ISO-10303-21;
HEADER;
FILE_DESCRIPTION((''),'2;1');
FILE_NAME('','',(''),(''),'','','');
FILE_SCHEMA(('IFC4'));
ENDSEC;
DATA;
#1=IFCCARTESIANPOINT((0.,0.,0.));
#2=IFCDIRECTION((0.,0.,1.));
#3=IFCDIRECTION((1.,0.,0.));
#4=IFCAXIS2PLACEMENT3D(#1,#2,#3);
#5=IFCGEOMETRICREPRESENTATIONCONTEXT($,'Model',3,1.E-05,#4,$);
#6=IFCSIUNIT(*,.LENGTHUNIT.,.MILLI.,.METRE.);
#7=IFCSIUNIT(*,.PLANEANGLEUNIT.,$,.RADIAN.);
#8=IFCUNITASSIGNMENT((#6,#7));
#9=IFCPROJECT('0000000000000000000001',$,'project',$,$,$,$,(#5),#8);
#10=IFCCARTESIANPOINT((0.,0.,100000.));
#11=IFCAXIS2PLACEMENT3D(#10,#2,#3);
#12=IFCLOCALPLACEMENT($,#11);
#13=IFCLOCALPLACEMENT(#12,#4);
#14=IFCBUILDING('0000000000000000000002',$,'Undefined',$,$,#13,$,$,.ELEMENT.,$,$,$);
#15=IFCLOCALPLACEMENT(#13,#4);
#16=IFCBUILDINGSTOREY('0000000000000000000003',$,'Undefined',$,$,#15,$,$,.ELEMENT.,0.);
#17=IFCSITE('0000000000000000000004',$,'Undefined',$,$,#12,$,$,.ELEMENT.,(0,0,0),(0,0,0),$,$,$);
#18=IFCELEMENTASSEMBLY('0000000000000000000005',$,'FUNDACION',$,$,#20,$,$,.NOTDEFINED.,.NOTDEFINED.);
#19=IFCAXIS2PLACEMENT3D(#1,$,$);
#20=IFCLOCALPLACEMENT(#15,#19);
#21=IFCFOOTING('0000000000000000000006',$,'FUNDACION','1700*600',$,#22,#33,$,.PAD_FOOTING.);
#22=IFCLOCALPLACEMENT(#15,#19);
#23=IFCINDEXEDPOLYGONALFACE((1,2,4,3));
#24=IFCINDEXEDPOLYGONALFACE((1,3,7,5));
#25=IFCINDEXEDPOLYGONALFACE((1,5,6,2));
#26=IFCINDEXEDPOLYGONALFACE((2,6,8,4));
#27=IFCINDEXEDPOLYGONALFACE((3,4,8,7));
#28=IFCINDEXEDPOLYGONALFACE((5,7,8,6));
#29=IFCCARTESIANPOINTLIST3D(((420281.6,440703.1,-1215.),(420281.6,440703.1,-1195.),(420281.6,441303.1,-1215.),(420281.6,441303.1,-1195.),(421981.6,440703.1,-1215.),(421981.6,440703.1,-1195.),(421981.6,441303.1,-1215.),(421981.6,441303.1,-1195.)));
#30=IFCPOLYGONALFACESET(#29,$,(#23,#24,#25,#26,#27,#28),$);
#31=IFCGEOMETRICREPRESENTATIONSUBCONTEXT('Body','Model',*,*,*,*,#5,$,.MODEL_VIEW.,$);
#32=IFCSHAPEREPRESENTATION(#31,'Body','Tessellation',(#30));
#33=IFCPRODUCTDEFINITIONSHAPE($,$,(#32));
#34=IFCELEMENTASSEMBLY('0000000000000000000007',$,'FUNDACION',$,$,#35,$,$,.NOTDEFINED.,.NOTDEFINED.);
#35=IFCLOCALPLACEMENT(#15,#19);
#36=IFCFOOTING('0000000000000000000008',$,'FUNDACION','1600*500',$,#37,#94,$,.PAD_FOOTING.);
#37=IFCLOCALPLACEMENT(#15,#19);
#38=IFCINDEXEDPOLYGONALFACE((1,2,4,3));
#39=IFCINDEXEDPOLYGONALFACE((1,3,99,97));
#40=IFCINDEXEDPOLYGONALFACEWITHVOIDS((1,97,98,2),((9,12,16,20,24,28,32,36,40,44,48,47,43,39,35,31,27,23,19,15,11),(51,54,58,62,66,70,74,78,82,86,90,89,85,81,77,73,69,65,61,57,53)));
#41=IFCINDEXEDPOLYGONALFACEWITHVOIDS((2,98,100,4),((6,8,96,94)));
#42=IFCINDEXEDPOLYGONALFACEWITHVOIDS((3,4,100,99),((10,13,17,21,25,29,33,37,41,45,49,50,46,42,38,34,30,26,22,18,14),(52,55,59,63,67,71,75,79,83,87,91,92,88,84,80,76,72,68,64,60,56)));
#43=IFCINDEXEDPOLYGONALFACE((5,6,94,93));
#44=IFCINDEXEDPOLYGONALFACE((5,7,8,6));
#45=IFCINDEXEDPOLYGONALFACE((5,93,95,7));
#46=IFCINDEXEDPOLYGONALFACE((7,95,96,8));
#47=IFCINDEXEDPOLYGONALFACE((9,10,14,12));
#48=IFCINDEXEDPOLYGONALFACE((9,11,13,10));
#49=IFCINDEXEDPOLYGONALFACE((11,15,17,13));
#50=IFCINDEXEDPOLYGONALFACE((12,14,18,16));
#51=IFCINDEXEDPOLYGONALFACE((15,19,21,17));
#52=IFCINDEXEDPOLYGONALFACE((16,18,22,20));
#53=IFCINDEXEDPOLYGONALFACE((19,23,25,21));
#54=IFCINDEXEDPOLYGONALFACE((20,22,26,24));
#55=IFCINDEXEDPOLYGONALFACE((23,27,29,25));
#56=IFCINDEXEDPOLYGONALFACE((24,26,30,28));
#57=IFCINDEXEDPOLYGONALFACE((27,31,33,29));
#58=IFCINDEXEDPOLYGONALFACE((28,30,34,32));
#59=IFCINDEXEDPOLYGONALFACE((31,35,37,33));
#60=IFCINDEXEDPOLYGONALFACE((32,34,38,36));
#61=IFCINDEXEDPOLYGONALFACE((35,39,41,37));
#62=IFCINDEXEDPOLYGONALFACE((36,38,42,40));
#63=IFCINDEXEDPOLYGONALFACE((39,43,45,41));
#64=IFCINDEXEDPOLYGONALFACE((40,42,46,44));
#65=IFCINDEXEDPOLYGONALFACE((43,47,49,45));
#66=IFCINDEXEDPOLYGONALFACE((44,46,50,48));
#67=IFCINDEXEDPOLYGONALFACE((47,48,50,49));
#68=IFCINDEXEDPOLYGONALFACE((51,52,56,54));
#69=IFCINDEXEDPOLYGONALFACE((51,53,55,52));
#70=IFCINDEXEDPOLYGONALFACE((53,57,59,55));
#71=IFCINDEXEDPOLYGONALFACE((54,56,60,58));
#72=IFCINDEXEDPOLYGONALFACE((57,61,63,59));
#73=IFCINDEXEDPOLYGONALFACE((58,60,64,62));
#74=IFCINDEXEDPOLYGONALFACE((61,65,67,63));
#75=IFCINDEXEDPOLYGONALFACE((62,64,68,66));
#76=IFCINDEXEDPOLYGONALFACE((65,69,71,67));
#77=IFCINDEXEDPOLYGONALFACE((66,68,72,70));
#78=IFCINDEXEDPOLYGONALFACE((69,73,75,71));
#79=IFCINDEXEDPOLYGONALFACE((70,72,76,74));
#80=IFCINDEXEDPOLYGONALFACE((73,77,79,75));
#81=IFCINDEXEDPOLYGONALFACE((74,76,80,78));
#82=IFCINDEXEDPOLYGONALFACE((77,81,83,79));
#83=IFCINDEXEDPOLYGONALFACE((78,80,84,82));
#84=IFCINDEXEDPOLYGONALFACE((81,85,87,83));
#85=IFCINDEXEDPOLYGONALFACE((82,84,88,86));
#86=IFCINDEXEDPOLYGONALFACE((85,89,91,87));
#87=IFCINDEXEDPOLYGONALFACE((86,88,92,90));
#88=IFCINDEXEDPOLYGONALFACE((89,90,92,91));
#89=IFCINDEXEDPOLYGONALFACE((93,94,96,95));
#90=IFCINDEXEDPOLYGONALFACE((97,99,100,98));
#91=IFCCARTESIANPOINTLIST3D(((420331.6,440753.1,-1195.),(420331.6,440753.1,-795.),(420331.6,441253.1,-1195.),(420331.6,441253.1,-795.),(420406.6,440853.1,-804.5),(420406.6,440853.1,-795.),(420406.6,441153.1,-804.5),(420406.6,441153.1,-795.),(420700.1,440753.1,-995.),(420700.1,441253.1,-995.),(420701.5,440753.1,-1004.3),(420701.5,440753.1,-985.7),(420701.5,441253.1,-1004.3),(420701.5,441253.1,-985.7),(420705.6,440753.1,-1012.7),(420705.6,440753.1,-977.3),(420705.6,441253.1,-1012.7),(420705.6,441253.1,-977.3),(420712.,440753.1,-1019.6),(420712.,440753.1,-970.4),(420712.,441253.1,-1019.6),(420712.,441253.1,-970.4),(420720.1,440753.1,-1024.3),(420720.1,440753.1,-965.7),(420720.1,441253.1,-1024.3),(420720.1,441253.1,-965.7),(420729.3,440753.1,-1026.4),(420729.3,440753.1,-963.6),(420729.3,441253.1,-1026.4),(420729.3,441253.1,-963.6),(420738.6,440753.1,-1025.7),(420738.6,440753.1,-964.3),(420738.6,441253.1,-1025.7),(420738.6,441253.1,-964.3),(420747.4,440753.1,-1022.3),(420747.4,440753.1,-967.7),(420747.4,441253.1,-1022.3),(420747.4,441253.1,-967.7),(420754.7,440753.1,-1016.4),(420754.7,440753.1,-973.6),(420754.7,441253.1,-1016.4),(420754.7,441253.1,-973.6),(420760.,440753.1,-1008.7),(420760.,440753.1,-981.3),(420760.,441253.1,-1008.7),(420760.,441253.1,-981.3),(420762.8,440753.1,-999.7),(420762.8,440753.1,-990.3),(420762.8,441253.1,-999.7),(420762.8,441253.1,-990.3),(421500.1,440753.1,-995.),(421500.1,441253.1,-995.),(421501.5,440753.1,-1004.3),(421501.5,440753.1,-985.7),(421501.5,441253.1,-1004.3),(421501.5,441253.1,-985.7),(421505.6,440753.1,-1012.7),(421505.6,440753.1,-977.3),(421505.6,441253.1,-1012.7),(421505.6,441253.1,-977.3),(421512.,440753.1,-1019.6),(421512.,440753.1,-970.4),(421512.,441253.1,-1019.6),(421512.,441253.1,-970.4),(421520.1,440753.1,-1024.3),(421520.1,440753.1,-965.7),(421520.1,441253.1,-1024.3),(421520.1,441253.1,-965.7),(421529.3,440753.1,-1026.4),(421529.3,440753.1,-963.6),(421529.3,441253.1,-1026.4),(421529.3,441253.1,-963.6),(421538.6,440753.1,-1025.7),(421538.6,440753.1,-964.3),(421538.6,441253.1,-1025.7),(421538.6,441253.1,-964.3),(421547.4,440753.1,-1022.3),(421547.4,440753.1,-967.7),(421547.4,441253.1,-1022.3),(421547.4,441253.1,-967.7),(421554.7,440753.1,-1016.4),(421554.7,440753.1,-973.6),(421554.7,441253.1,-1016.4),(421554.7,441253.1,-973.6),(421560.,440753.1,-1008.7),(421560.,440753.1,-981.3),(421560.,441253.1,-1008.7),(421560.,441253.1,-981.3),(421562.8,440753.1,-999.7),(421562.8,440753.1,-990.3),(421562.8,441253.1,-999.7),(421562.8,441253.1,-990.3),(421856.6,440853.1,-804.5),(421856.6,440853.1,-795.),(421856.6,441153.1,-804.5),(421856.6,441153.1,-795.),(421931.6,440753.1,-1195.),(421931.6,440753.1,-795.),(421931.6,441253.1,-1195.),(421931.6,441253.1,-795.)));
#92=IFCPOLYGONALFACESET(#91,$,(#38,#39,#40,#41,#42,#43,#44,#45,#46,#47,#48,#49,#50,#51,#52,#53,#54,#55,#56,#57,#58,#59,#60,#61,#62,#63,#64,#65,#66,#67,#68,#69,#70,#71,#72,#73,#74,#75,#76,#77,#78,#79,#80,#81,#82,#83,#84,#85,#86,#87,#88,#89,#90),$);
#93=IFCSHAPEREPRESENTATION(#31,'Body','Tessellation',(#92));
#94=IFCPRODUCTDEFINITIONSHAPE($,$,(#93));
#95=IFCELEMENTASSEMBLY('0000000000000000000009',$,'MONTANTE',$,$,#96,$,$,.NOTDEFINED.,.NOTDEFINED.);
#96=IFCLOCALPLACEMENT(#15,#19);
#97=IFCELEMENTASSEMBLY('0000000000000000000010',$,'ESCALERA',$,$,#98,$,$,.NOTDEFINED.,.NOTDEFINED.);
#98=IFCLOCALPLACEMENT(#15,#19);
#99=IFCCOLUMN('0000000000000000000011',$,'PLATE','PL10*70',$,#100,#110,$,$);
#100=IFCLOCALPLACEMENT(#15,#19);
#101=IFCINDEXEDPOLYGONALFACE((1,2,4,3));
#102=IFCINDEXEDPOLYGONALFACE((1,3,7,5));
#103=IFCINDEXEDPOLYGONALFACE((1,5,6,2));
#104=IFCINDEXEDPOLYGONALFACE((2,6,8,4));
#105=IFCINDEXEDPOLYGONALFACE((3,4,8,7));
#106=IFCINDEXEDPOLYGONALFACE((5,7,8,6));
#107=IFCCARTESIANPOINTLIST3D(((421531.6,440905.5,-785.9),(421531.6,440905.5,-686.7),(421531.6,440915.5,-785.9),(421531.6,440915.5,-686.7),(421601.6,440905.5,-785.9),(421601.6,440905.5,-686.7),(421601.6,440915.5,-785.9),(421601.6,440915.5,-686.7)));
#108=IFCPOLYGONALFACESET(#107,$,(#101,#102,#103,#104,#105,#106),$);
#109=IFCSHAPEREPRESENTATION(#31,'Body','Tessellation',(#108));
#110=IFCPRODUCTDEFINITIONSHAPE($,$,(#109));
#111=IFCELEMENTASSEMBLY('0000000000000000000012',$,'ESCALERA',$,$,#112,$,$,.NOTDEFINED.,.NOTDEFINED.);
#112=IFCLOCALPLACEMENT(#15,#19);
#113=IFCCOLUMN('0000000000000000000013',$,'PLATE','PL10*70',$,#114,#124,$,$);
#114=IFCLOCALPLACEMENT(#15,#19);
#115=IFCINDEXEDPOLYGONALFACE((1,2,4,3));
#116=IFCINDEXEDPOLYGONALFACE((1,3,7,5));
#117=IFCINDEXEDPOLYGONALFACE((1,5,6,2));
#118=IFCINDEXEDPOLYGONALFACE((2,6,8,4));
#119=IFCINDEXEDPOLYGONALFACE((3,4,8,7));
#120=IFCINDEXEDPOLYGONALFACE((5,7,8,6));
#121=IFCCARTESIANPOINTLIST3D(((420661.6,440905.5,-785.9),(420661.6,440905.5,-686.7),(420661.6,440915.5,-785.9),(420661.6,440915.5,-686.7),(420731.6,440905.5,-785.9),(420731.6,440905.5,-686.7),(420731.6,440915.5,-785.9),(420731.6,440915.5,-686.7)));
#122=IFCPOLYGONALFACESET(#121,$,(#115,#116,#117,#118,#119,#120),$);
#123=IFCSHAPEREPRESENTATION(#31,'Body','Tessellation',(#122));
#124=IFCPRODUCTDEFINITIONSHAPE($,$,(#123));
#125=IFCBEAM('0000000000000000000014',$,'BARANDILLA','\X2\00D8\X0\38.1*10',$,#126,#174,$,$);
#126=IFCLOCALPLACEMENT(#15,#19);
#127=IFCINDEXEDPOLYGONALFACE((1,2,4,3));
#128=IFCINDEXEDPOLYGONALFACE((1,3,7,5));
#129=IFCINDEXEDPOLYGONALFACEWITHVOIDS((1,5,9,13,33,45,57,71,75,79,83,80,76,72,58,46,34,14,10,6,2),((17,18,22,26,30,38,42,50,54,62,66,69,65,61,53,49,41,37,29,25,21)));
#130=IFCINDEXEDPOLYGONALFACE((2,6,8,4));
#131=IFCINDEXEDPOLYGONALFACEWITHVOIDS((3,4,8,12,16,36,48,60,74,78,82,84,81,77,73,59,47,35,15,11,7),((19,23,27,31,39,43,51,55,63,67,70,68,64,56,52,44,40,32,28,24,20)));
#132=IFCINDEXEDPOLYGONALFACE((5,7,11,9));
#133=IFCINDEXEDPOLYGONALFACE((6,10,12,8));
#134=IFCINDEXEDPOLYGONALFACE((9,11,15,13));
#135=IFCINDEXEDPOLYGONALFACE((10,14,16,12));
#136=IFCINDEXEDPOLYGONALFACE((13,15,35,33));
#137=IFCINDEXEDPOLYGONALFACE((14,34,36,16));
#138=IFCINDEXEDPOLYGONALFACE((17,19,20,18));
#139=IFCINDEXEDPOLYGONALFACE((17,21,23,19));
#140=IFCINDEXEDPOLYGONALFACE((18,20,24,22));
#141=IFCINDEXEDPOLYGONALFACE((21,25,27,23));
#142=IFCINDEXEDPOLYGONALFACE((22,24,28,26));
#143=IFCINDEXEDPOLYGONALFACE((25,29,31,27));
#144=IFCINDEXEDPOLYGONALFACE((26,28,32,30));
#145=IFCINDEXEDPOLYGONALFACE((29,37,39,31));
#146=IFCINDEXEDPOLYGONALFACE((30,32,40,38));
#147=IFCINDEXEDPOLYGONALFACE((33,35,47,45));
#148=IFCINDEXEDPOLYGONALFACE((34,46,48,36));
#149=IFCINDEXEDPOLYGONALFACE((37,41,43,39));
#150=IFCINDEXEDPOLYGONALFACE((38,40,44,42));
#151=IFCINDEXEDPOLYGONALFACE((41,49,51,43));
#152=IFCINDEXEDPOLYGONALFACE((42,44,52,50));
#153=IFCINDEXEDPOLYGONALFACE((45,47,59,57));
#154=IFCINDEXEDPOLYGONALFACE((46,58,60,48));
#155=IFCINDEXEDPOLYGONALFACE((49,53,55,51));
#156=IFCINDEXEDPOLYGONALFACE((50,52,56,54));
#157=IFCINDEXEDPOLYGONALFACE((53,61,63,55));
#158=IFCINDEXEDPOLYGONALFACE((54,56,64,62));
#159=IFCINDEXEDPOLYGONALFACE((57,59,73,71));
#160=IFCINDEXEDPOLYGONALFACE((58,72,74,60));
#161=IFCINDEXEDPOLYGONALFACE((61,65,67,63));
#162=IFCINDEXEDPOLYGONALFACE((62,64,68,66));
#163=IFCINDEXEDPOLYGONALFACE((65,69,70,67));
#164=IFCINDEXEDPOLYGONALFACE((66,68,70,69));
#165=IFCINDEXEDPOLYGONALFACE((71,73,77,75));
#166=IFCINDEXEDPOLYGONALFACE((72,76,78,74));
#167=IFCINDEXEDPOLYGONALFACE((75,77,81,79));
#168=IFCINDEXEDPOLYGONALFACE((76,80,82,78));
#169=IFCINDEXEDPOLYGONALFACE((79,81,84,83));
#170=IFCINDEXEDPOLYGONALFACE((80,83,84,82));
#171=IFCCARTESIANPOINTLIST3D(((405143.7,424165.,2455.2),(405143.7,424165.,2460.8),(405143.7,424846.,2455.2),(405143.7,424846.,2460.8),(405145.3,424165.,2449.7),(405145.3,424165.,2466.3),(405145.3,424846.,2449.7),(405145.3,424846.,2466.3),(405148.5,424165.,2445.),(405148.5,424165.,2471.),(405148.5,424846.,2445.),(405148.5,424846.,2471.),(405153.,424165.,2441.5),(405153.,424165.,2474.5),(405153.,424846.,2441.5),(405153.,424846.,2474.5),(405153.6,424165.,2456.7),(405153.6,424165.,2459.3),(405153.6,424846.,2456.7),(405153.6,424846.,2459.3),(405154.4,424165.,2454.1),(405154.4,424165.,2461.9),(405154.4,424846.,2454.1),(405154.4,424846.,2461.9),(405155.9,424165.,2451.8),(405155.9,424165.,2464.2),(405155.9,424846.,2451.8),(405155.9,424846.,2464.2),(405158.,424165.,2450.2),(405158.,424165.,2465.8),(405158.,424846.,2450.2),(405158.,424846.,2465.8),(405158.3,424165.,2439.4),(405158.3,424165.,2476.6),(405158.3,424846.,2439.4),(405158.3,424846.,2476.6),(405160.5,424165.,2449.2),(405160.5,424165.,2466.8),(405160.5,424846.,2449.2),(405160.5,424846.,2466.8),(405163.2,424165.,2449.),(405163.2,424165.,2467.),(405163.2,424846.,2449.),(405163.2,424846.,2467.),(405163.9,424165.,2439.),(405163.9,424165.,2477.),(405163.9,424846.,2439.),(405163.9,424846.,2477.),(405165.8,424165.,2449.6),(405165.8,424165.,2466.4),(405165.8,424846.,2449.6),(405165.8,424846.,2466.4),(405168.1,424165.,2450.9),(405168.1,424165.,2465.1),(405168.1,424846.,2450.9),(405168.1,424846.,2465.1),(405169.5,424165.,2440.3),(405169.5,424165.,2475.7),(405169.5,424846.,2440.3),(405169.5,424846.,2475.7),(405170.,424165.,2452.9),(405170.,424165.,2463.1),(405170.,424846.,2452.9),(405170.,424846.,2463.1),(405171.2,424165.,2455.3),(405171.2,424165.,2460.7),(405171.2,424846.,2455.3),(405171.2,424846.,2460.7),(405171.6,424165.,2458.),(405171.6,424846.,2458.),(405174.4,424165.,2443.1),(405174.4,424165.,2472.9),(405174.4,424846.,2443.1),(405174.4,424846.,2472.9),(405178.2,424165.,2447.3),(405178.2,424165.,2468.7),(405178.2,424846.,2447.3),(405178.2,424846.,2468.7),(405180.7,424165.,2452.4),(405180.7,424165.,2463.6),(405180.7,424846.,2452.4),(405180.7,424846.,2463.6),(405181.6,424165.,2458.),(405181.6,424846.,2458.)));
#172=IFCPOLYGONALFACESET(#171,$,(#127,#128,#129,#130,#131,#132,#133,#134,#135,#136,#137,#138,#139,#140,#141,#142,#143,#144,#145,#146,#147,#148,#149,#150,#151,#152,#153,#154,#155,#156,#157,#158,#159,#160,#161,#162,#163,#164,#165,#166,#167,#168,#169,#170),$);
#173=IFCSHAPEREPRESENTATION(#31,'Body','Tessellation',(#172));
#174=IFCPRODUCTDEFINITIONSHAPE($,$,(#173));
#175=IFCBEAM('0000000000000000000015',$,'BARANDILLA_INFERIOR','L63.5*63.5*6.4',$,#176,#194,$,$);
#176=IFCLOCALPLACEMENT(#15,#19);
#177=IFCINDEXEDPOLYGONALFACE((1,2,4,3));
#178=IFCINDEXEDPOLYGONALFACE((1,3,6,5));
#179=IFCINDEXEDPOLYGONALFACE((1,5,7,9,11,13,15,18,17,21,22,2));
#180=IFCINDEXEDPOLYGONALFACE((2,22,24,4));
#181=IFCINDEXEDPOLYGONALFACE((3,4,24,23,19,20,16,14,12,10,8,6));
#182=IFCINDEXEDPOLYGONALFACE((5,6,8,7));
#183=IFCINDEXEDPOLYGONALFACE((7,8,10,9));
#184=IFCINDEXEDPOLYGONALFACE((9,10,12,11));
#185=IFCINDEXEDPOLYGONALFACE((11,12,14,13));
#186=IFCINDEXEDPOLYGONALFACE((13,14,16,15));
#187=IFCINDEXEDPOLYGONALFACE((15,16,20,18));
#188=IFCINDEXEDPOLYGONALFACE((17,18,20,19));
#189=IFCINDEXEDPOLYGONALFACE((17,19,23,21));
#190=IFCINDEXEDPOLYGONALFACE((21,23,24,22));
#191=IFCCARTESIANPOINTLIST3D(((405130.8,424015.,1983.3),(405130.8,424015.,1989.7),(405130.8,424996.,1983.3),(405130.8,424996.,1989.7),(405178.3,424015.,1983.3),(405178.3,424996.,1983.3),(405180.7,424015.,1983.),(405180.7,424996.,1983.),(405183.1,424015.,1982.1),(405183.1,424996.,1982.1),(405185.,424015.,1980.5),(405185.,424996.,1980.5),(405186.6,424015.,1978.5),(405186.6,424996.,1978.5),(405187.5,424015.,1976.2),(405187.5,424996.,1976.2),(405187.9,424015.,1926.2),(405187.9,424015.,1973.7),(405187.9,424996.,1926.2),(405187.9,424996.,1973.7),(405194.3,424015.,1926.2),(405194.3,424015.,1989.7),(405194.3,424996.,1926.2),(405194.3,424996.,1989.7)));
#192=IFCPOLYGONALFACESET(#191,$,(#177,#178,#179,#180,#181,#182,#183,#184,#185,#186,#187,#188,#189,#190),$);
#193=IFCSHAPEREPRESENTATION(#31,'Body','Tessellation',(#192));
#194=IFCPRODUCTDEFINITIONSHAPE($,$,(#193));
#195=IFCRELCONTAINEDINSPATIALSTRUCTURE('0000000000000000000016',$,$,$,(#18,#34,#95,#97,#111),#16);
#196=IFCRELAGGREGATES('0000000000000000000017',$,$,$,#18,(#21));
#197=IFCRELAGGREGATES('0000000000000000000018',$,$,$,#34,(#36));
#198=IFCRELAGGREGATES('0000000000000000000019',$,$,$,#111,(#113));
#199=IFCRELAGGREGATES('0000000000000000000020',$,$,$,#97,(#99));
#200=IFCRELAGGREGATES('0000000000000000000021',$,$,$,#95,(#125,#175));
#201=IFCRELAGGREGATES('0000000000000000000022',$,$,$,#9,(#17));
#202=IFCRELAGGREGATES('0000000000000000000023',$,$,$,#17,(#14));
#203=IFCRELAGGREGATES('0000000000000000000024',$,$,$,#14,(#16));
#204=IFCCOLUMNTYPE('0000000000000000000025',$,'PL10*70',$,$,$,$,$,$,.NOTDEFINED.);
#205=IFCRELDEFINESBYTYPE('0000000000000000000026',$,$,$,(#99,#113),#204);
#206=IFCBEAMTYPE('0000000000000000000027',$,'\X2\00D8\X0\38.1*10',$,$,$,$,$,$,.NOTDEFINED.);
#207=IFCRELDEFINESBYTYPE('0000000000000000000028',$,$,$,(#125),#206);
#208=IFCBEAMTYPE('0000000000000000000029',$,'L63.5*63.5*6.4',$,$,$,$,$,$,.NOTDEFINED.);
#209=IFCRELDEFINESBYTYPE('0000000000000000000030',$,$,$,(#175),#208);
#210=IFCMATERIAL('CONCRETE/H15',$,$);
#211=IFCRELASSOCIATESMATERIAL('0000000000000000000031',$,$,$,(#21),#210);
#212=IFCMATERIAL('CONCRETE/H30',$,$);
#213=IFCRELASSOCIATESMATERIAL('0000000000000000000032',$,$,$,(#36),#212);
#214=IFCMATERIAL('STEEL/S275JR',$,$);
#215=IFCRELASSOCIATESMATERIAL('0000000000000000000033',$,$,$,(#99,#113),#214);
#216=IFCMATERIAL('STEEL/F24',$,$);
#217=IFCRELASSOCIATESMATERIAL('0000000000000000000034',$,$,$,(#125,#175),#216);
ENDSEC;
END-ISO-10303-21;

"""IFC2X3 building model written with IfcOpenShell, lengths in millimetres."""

from ifc_helpers import new_model, si_unit, frame, origin_with_axes, origin_2d_with_axis, place, context, subcontext, project, spatial, polyline, rectangle, circle, hollow_circle, l_section, outline, extrude, boolean, clip, halfspace, material, type_object, element, aggregate, save


model = new_model("IFC2X3")

# Units and contexts
model_context = context("Model", 3, precision=1e-05, world=origin_with_axes())
body_context = subcontext(model_context, "Body", "Model", "MODEL_VIEW")
ifc_project = project(units=[si_unit("LENGTHUNIT", "METRE", prefix="MILLI"), si_unit("PLANEANGLEUNIT", "RADIAN")], contexts=[model_context])

# Site, building, storey
site_placement = place(None, frame((0.0, 0.0, 100000.0), z_axis=(0.0, 0.0, 1.0), x_axis=(1.0, 0.0, 0.0)))
site = spatial("IfcSite", under=ifc_project, at=site_placement, Name="Undefined", CompositionType="ELEMENT", RefLatitude=(0, 0, 0), RefLongitude=(0, 0, 0))
building_placement = place(site_placement, origin_with_axes())
building = spatial("IfcBuilding", under=site, at=building_placement, Name="Undefined", CompositionType="ELEMENT")
storey_placement = place(building_placement, origin_with_axes())
storey = spatial("IfcBuildingStorey", under=building, at=storey_placement, Name="Undefined", CompositionType="ELEMENT", Elevation=0.0)

# Element assemblies, footings
assembly_1_placement = place(storey_placement, origin_with_axes())
assembly_1 = element("IfcElementAssembly", 1, at=assembly_1_placement, inside=storey, Name="FUNDACION", AssemblyPlace="NOTDEFINED", PredefinedType="NOTDEFINED")
ifc_material_1 = material(Name="CONCRETE/H15")
footing_1_placement = place(assembly_1_placement, frame((421131.6, 441003.1, -1215.0), z_axis=(1.0, 0.0, 0.0), x_axis=(0.0, 0.0, 1.0)))
footing_1 = element("IfcFooting", 2, at=footing_1_placement, material=ifc_material_1, Name="FUNDACION", Description="1700*600", PredefinedType="PAD_FOOTING", context=body_context, shape_type="SweptSolid", body=[
    extrude(rectangle(XDim=600.0, YDim=1700.0, at=origin_2d_with_axis()), frame((20.0, 0.0, 0.0), z_axis=(-1.0, 0.0, 0.0), x_axis=(0.0, -1.0, 0.0)), (0.0, 0.0, 1.0), 20.0),
])
aggregate(assembly_1, [footing_1])
assembly_2_placement = place(storey_placement, origin_with_axes())
assembly_2 = element("IfcElementAssembly", 3, at=assembly_2_placement, inside=storey, Name="FUNDACION", AssemblyPlace="NOTDEFINED", PredefinedType="NOTDEFINED")
ifc_material_2 = material(Name="CONCRETE/H30")
footing_2_placement = place(assembly_2_placement, frame((421131.6, 441003.1, -1195.0), z_axis=(1.0, 0.0, 0.0), x_axis=(0.0, 0.0, 1.0)))
footing_2 = element("IfcFooting", 4, at=footing_2_placement, material=ifc_material_2, Name="FUNDACION", Description="1600*500", PredefinedType="PAD_FOOTING", context=body_context, shape_type="CSG", body=[
    boolean("DIFFERENCE", boolean("DIFFERENCE", boolean("DIFFERENCE", extrude(rectangle(XDim=500.0, YDim=1600.0, at=origin_2d_with_axis()), frame((400.0, 0.0, 0.0), z_axis=(-1.0, 0.0, 0.0), x_axis=(0.0, -1.0, 0.0)), (0.0, 0.0, 1.0), 400.0), extrude(circle(Radius=31.5, at=origin_2d_with_axis()), frame((200.0, 300.0, 400.0), z_axis=(0.0, -1.0, 0.0), x_axis=(0.0, 0.0, -1.0)), (0.0, 0.0, 1.0), 600.0)), extrude(circle(Radius=31.5, at=origin_2d_with_axis()), frame((200.0, 300.0, -400.0), z_axis=(0.0, -1.0, 0.0), x_axis=(0.0, 0.0, -1.0)), (0.0, 0.0, 1.0), 600.0)), extrude(outline(polyline([(0.0, 0.0), (1450.0, 0.0), (1450.0, 300.0), (0.0, 300.0), (0.0, 0.0)])), frame((390.5, -150.0, 725.0), z_axis=(1.0, 0.0, 0.0), x_axis=(0.0, 0.0, -1.0)), (0.0, 0.0, 1.0), 19.0)),
])
aggregate(assembly_2, [footing_2])

# Shared definitions
ifc_material_3 = material(Name="STEEL/F24")

# Element assemblies, columns
assembly_3_placement = place(storey_placement, origin_with_axes())
assembly_3 = element("IfcElementAssembly", 5, at=assembly_3_placement, inside=storey, Name="MONTANTE", AssemblyPlace="NOTDEFINED", PredefinedType="NOTDEFINED")
assembly_4_placement = place(storey_placement, origin_with_axes())
assembly_4 = element("IfcElementAssembly", 6, at=assembly_4_placement, inside=storey, Name="ESCALERA", AssemblyPlace="NOTDEFINED", PredefinedType="NOTDEFINED")
ifc_material_4 = material(Name="STEEL/S275JR")
column_type_1 = type_object("IfcColumnType", Name="PL10*70", PredefinedType="NOTDEFINED")
column_1_placement = place(assembly_4_placement, frame((421566.6, 440910.5, -785.9), z_axis=(0.0, 0.0, 1.0), x_axis=(1.0, 0.0, 0.0)))
column_1 = element("IfcColumn", 7, at=column_1_placement, type_object=column_type_1, material=ifc_material_4, Name="PLATE", Description="PL10*70", context=body_context, shape_type="SweptSolid", body=[
    extrude(rectangle(XDim=10.0, YDim=70.0, at=origin_2d_with_axis()), frame((0.0, 0.0, 99.2), z_axis=(0.0, 0.0, -1.0), x_axis=(0.0, 1.0, 0.0)), (0.0, 0.0, 1.0), 99.2),
])
assembly_5_placement = place(storey_placement, origin_with_axes())
assembly_5 = element("IfcElementAssembly", 8, at=assembly_5_placement, inside=storey, Name="ESCALERA", AssemblyPlace="NOTDEFINED", PredefinedType="NOTDEFINED")
column_2_placement = place(assembly_5_placement, frame((420696.6, 440910.5, -785.9), z_axis=(0.0, 0.0, 1.0), x_axis=(1.0, 0.0, 0.0)))
column_2 = element("IfcColumn", 9, at=column_2_placement, type_object=column_type_1, material=ifc_material_4, Name="PLATE", Description="PL10*70", context=body_context, shape_type="SweptSolid", body=[
    extrude(rectangle(XDim=10.0, YDim=70.0, at=origin_2d_with_axis()), frame((0.0, 0.0, 99.2), z_axis=(0.0, 0.0, -1.0), x_axis=(0.0, 1.0, 0.0)), (0.0, 0.0, 1.0), 99.2),
])

# Beams
beam_type_1 = type_object("IfcBeamType", Name="Ø38.1*10", PredefinedType="NOTDEFINED")
beam_1_placement = place(assembly_3_placement, frame((405162.5, 424846.0, 2458.0), z_axis=(0.0, 0.0, -1.0), x_axis=(0.0, -1.0, 0.0)))
beam_1 = element("IfcBeam", 10, at=beam_1_placement, type_object=beam_type_1, material=ifc_material_3, Name="BARANDILLA", Description="Ø38.1*10", context=body_context, shape_type="Clipping", body=[
    clip(clip(extrude(hollow_circle(Radius=19.1, WallThickness=10.0, at=origin_2d_with_axis()), frame((681.0, 0.0, 0.0), z_axis=(-1.0, 0.0, 0.0), x_axis=(0.0, -1.0, 0.0)), (0.0, 0.0, 1.0), 681.0), halfspace(frame((681.0, 0.0, 0.0), z_axis=(1.0, 0.0, 0.0), x_axis=(0.0, -1.0, 0.0)), False)), halfspace(frame((0.0, 0.0, 0.0), z_axis=(1.0, 0.0, 0.0), x_axis=(0.0, -1.0, 0.0)), True)),
])
beam_type_2 = type_object("IfcBeamType", Name="L63.5*63.5*6.4", PredefinedType="NOTDEFINED")
beam_2_placement = place(assembly_3_placement, frame((405162.5, 424996.0, 1958.0), z_axis=(-1.0, 0.0, 0.0), x_axis=(0.0, -1.0, 0.0)))
beam_2 = element("IfcBeam", 11, at=beam_2_placement, type_object=beam_type_2, material=ifc_material_3, Name="BARANDILLA_INFERIOR", Description="L63.5*63.5*6.4", context=body_context, shape_type="SweptSolid", body=[
    extrude(l_section(Depth=63.5, Width=63.5, Thickness=6.4, FilletRadius=9.6, at=origin_2d_with_axis()), frame((981.0, 0.0, 0.0), z_axis=(-1.0, 0.0, 0.0), x_axis=(0.0, -1.0, 0.0)), (0.0, 0.0, 1.0), 981.0),
])

aggregate(assembly_5, [column_2])

aggregate(assembly_4, [column_1])

aggregate(assembly_3, [beam_1, beam_2])

save(model, "model.ifc")
